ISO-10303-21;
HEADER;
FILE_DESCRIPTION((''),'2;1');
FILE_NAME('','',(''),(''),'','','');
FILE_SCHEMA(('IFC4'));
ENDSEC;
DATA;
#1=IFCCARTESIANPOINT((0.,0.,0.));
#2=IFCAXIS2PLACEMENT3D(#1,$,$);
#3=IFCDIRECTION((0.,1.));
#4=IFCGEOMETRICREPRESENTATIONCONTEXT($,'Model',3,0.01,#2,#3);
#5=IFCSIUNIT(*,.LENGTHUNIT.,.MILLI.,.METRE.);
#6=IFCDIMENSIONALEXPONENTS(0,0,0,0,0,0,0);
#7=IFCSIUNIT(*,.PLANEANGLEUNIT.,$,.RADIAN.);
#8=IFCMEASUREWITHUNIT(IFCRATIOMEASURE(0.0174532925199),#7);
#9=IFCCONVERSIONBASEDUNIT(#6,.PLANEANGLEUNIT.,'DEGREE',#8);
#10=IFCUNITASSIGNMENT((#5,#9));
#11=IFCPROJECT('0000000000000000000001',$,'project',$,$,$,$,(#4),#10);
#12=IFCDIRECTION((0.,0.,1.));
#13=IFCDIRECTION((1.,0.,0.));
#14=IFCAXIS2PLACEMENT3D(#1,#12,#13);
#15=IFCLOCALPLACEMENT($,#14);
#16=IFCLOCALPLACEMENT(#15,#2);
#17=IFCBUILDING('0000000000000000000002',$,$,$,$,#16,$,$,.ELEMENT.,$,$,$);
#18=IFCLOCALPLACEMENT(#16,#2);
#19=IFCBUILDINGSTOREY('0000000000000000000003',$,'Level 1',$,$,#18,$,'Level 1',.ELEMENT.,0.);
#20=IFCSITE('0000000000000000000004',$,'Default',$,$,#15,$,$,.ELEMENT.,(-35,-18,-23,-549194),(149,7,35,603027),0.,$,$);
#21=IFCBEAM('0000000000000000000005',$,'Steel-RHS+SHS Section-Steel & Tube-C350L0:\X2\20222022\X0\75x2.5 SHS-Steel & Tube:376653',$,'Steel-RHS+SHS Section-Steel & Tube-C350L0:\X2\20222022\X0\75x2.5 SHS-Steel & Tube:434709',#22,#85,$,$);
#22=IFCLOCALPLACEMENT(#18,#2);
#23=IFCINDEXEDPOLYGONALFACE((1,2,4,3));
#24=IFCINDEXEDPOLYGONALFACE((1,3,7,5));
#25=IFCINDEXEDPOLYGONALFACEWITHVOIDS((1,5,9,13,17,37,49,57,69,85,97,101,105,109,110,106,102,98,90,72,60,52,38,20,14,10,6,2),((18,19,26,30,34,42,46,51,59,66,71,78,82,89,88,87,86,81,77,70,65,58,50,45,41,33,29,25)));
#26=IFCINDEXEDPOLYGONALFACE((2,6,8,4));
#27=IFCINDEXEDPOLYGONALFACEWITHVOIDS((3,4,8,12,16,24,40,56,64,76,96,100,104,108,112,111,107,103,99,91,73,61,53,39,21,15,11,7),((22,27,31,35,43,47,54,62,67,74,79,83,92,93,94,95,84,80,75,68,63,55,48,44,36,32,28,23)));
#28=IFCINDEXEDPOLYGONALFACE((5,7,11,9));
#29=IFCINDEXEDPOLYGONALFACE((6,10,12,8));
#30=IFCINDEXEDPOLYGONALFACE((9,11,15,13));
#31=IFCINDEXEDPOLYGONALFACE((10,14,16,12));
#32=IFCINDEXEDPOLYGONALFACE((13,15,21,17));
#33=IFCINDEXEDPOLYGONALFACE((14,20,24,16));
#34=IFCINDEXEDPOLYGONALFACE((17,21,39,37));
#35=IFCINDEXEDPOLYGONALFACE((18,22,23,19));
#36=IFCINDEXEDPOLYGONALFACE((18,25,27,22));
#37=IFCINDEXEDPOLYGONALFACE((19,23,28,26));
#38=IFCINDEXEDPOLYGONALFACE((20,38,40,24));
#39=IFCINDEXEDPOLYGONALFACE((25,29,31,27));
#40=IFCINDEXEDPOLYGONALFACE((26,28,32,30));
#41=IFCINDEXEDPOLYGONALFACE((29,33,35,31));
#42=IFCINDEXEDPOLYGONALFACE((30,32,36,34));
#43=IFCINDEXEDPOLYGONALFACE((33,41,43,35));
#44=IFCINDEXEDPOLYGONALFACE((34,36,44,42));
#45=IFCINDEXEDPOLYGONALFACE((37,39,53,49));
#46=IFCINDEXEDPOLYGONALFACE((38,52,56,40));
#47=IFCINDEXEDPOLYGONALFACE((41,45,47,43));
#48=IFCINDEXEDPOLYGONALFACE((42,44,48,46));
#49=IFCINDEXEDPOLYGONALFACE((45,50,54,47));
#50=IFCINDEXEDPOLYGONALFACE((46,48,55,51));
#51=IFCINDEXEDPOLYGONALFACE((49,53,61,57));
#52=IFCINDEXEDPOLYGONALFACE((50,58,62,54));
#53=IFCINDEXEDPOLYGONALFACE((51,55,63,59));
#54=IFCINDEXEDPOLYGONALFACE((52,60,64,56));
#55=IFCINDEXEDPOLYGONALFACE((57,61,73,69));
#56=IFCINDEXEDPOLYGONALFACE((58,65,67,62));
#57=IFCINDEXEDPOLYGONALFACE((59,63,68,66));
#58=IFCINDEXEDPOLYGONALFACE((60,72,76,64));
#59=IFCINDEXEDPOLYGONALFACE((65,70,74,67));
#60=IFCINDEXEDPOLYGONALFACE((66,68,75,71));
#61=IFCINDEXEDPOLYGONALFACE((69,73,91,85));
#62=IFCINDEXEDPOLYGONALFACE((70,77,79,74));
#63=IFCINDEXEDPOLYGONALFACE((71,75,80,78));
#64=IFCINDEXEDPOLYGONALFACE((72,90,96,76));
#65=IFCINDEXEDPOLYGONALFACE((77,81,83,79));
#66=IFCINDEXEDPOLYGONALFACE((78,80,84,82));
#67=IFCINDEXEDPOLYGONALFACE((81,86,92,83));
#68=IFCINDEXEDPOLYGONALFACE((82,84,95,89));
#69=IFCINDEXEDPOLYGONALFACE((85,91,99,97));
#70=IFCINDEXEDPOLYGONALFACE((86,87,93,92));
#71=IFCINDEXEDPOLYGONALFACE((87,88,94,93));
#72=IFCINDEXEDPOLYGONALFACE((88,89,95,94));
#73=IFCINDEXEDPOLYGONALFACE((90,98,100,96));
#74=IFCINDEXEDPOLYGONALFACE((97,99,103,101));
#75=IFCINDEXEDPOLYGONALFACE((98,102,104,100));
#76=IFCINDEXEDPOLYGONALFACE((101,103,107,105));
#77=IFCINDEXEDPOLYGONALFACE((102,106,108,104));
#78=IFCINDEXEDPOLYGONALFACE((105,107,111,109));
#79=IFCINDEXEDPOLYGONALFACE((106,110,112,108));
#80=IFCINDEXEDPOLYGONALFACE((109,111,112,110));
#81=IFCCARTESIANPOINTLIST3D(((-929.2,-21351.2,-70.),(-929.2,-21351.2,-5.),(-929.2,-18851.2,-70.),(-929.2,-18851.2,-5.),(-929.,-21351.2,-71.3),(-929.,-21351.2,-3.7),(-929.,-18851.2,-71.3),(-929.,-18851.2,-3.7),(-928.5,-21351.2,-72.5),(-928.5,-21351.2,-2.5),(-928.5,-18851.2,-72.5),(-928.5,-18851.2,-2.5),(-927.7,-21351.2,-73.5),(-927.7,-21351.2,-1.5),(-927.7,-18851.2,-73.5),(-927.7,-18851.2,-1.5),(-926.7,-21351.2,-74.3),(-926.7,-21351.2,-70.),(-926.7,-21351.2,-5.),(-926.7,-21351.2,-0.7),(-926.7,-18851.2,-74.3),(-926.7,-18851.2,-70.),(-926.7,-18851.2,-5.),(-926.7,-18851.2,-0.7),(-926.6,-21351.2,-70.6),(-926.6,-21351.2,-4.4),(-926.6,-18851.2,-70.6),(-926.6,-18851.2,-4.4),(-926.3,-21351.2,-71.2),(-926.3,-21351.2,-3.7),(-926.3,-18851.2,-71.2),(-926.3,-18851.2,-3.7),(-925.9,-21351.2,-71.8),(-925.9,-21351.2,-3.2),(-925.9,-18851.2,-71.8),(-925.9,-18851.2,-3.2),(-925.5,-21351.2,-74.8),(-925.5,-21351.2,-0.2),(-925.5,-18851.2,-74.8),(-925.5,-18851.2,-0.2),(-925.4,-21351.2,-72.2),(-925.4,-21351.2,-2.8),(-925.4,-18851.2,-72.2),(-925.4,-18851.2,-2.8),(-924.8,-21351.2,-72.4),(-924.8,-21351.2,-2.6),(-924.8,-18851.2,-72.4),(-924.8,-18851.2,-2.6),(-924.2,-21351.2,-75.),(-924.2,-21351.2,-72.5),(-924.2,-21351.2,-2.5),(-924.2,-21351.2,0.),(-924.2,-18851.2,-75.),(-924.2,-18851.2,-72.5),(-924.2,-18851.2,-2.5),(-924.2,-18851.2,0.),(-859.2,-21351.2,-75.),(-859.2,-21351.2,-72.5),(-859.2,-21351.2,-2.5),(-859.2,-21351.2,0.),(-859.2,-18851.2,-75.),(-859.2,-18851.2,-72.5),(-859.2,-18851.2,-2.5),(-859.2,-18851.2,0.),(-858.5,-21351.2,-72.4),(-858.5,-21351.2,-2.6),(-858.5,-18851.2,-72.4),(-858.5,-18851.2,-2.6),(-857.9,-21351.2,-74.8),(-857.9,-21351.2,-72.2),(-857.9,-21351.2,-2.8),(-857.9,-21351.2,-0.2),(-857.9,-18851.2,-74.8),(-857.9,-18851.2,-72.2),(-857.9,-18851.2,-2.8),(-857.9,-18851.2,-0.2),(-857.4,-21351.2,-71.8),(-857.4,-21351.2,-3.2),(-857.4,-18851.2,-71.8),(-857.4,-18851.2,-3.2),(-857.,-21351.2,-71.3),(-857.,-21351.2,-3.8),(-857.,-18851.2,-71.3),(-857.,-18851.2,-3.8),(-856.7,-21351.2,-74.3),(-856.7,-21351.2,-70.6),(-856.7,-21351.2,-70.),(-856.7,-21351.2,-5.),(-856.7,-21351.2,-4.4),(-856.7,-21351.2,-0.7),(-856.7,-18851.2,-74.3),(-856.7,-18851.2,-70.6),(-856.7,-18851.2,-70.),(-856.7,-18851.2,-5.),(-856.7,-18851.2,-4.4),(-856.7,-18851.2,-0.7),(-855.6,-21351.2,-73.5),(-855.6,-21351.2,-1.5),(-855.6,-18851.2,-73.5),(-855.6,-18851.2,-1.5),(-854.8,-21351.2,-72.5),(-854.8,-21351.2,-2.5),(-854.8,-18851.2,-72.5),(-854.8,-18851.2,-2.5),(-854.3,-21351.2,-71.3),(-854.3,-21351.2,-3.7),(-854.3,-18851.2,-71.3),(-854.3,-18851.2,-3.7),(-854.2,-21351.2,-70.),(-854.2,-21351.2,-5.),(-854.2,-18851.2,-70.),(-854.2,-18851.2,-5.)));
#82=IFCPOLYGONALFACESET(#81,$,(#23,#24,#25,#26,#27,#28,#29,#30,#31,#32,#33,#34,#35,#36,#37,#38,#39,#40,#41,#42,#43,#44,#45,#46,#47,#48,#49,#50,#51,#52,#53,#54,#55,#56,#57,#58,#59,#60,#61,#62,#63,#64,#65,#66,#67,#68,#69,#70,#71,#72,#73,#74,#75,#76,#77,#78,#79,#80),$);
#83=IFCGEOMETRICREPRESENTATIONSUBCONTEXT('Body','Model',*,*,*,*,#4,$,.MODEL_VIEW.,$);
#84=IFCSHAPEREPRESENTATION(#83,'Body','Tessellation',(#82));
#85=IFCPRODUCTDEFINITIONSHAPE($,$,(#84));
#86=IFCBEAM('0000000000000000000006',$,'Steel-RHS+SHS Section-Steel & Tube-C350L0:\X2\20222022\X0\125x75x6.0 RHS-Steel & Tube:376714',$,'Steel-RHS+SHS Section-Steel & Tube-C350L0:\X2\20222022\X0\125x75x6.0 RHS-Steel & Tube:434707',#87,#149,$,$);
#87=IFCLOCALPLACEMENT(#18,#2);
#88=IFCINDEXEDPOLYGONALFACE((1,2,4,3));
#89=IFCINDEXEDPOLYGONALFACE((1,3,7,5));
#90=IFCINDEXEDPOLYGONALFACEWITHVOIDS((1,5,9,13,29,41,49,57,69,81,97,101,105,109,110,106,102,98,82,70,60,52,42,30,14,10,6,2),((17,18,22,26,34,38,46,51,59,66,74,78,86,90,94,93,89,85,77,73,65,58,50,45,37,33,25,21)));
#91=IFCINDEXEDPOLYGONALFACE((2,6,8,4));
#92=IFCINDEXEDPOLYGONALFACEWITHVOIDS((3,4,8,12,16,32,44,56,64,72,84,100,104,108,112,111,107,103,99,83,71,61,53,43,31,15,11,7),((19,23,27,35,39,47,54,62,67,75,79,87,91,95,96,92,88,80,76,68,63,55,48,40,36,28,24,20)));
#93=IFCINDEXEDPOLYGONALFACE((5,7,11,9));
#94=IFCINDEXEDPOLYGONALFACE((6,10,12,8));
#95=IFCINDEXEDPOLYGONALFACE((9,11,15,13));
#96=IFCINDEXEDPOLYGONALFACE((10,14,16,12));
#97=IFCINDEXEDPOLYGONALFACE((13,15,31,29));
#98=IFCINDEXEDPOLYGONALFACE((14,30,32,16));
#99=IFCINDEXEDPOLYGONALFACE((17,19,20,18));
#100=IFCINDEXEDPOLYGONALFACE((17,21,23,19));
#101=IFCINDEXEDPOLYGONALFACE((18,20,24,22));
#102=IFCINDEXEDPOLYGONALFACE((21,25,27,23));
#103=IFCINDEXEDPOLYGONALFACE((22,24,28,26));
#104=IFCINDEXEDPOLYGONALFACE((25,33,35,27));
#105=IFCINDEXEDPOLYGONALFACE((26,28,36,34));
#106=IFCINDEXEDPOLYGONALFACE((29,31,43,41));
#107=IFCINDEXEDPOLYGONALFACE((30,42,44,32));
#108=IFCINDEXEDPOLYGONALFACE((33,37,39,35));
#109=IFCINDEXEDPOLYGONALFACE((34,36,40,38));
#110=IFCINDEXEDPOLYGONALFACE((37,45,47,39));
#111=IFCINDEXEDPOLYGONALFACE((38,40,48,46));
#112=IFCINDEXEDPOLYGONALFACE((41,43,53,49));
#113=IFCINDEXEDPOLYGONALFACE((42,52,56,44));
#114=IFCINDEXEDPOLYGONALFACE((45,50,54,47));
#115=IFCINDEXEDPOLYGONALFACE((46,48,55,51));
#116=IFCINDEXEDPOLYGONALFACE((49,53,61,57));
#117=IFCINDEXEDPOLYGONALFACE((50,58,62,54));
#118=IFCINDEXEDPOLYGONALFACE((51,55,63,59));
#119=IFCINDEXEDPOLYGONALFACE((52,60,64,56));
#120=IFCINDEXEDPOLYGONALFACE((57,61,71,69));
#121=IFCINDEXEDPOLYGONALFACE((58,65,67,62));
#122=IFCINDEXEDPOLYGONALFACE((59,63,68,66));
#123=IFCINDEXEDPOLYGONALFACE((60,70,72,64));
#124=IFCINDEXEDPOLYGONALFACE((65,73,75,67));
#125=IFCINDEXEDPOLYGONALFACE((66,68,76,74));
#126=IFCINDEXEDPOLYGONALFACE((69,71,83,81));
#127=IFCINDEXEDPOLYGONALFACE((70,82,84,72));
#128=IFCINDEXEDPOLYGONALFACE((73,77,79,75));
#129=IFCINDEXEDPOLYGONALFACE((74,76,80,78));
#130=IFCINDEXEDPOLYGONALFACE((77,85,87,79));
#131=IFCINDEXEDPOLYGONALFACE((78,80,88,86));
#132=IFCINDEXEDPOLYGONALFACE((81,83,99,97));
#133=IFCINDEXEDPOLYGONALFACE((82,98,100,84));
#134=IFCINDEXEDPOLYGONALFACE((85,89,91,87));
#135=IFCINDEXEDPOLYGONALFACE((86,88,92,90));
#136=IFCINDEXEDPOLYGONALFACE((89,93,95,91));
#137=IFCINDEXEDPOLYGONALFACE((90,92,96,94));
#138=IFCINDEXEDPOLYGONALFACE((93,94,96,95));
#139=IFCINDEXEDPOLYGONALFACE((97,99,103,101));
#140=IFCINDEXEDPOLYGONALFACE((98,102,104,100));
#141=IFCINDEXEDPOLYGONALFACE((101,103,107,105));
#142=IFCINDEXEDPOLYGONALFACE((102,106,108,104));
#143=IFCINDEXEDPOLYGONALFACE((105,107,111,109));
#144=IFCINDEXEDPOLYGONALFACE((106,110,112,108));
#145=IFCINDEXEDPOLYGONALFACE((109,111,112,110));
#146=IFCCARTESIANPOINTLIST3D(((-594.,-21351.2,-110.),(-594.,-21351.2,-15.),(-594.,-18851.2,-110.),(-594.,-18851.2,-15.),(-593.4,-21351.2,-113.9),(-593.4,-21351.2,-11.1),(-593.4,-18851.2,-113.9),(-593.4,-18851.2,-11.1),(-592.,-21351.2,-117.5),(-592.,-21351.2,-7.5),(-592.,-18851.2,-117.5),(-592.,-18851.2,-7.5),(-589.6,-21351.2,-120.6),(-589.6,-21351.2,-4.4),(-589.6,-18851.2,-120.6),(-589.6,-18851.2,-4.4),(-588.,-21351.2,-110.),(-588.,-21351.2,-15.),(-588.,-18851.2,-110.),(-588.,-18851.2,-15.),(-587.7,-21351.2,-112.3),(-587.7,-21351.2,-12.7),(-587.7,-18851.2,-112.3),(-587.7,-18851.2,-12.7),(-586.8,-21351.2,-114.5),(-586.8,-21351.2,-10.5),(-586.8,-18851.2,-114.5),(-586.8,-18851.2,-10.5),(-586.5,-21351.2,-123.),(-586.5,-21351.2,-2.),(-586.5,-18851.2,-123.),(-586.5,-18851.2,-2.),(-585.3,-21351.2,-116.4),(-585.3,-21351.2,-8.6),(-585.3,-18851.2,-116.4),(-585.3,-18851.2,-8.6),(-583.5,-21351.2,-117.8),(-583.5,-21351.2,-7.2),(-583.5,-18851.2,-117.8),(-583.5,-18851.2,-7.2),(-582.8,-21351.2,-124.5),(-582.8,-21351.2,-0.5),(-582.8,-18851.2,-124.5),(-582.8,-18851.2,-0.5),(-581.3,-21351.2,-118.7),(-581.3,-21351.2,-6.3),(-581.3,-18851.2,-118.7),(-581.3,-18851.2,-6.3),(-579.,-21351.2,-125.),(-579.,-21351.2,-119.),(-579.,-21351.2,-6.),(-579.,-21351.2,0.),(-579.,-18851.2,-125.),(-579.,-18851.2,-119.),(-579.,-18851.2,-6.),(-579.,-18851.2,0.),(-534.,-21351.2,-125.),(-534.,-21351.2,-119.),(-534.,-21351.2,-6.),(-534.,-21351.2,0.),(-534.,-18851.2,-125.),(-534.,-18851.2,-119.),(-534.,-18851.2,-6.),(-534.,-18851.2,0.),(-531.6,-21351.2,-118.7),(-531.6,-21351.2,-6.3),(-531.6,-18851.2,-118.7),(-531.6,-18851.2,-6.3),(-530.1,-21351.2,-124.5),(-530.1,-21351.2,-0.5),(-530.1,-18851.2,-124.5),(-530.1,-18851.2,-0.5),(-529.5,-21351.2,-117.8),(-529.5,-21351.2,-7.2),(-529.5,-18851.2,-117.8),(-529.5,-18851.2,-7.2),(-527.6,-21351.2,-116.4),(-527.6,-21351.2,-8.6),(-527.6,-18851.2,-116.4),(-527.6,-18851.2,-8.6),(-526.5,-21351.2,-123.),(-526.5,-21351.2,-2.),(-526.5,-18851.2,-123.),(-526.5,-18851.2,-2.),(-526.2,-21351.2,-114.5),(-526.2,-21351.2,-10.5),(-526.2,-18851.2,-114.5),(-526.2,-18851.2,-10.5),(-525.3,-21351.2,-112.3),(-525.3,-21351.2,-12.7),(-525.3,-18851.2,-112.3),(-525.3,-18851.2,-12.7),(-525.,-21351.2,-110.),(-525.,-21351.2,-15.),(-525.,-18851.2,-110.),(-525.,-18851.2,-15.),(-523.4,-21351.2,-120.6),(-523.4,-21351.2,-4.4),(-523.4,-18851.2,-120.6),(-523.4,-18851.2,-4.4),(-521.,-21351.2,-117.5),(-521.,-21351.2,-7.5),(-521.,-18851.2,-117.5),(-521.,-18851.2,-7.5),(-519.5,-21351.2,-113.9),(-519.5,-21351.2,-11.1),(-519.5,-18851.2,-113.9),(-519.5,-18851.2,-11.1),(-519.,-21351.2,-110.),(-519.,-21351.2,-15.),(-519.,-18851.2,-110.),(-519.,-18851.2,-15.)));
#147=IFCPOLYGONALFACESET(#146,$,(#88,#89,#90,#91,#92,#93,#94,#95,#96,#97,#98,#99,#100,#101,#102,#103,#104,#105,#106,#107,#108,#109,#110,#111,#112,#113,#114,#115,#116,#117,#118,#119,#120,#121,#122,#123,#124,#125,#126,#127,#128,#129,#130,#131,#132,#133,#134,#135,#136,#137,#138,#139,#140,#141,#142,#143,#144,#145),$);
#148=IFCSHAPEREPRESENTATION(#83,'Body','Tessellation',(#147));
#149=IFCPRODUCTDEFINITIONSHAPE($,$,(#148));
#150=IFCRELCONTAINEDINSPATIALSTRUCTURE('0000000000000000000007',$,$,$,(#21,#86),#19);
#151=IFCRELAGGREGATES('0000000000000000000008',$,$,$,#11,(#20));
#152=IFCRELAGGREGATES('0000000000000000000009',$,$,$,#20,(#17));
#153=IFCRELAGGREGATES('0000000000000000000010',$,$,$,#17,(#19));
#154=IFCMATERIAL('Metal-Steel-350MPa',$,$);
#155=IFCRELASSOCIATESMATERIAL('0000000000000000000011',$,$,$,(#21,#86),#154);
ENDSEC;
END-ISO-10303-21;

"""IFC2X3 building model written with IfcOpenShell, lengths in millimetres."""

from ifc_helpers import new_model, entity, si_unit, converted_unit, direction, frame, frame_2d, origin, origin_with_axes, place, context, subcontext, project, spatial, polyline, circle_curve, parameter, trimmed, segment, composite_curve, outline, extrude, material, element, save


model = new_model("IFC2X3")

# Units and contexts
model_context = context("Model", 3, precision=0.01, world=origin(), true_north=direction((0.0, 1.0)))
body_context = subcontext(model_context, "Body", "Model", "MODEL_VIEW")
ifc_project = project(units=[si_unit("LENGTHUNIT", "METRE", prefix="MILLI"), converted_unit("PLANEANGLEUNIT", "DEGREE", entity("IfcRatioMeasure", 0.0174532925199), si_unit("PLANEANGLEUNIT", "RADIAN"), dimensions=[0, 0, 0, 0, 0, 0, 0])], contexts=[model_context])

# Site, building, storey
site_placement = place(None, origin_with_axes())
site = spatial("IfcSite", under=ifc_project, at=site_placement, Name="Default", CompositionType="ELEMENT", RefLatitude=(-35, -18, -23, -549194), RefLongitude=(149, 7, 35, 603027), RefElevation=0.0)
building_placement = place(site_placement, origin())
building = spatial("IfcBuilding", under=site, at=building_placement, CompositionType="ELEMENT")
storey_placement = place(building_placement, origin())
storey = spatial("IfcBuildingStorey", under=building, at=storey_placement, Name="Level 1", LongName="Level 1", CompositionType="ELEMENT", Elevation=0.0)

# Beams
ifc_material = material(Name="Metal-Steel-350MPa")
beam_1_placement = place(storey_placement, frame((-891.7, -18851.2, 0.0), z_axis=(0.0, 0.0, 1.0), x_axis=(0.0, -1.0, 0.0)))
element("IfcBeam", 1, at=beam_1_placement, inside=storey, material=ifc_material, Name="Steel-RHS+SHS Section-Steel & Tube-C350L0:••75x2.5 SHS-Steel & Tube:376653", ObjectType="Steel-RHS+SHS Section-Steel & Tube-C350L0:••75x2.5 SHS-Steel & Tube:434709", context=body_context, shape_type="SweptSolid", body=[
    extrude(outline(composite_curve([segment(trimmed(circle_curve(frame_2d((-32.5, -32.5), x_axis=(1.0, 0.0)), 5.0), [parameter(180.0)], [parameter(270.0)], True, "PARAMETER"), True, "CONTINUOUS"), segment(polyline([(-32.5, -37.5), (32.5, -37.5)]), True, "CONTINUOUS"), segment(trimmed(circle_curve(frame_2d((32.5, -32.5), x_axis=(1.0, 0.0)), 5.0), [parameter(270.0)], [parameter(0.0)], True, "PARAMETER"), True, "CONTINUOUS"), segment(polyline([(37.5, -32.5), (37.5, 32.5)]), True, "CONTINUOUS"), segment(trimmed(circle_curve(frame_2d((32.5, 32.5), x_axis=(1.0, 0.0)), 5.0), [parameter(0.0)], [parameter(90.0)], True, "PARAMETER"), True, "CONTINUOUS"), segment(polyline([(32.5, 37.5), (-32.5, 37.5)]), True, "CONTINUOUS"), segment(trimmed(circle_curve(frame_2d((-32.5, 32.5), x_axis=(1.0, 0.0)), 5.0), [parameter(90.0)], [parameter(180.0)], True, "PARAMETER"), True, "CONTINUOUS"), segment(polyline([(-37.5, 32.5), (-37.5, -32.5)]), True, "CONTINUOUS")], self_intersect=False), holes=[composite_curve([segment(polyline([(32.5, -35.0), (-32.5, -35.0)]), True, "CONTINUOUS"), segment(trimmed(circle_curve(frame_2d((-32.5, -32.5), x_axis=(1.0, 0.0)), 2.5), [parameter(180.0)], [parameter(270.0)], True, "PARAMETER"), False, "CONTINUOUS"), segment(polyline([(-35.0, -32.5), (-35.0, 32.5)]), True, "CONTINUOUS"), segment(trimmed(circle_curve(frame_2d((-32.5, 32.5), x_axis=(1.0, 0.0)), 2.5), [parameter(90.0)], [parameter(180.0)], True, "PARAMETER"), False, "CONTINUOUS"), segment(polyline([(-32.5, 35.0), (32.5, 35.0)]), True, "CONTINUOUS"), segment(trimmed(circle_curve(frame_2d((32.5, 32.5), x_axis=(1.0, 0.0)), 2.5), [parameter(360.0)], [parameter(90.0)], True, "PARAMETER"), False, "CONTINUOUS"), segment(polyline([(35.0, 32.5), (35.0, -32.5)]), True, "CONTINUOUS"), segment(trimmed(circle_curve(frame_2d((32.5, -32.5), x_axis=(1.0, 0.0)), 2.5), [parameter(270.0)], [parameter(0.0)], True, "PARAMETER"), False, "CONTINUOUS")], self_intersect=False)]), frame((0.0, 0.0, -37.5), z_axis=(1.0, 0.0, 0.0), x_axis=(0.0, -1.0, 0.0)), (0.0, 0.0, 1.0), 2500.0),
])
beam_2_placement = place(storey_placement, frame((-556.5, -18851.2, 0.0), z_axis=(0.0, 0.0, 1.0), x_axis=(0.0, -1.0, 0.0)))
element("IfcBeam", 2, at=beam_2_placement, inside=storey, material=ifc_material, Name="Steel-RHS+SHS Section-Steel & Tube-C350L0:••125x75x6.0 RHS-Steel & Tube:376714", ObjectType="Steel-RHS+SHS Section-Steel & Tube-C350L0:••125x75x6.0 RHS-Steel & Tube:434707", context=body_context, shape_type="SweptSolid", body=[
    extrude(outline(composite_curve([segment(trimmed(circle_curve(frame_2d((-22.5, -47.5), x_axis=(1.0, 0.0)), 15.0), [parameter(180.0)], [parameter(270.0)], True, "PARAMETER"), True, "CONTINUOUS"), segment(polyline([(-22.5, -62.5), (22.5, -62.5)]), True, "CONTINUOUS"), segment(trimmed(circle_curve(frame_2d((22.5, -47.5), x_axis=(1.0, 0.0)), 15.0), [parameter(270.0)], [parameter(0.0)], True, "PARAMETER"), True, "CONTINUOUS"), segment(polyline([(37.5, -47.5), (37.5, 47.5)]), True, "CONTINUOUS"), segment(trimmed(circle_curve(frame_2d((22.5, 47.5), x_axis=(1.0, 0.0)), 15.0), [parameter(0.0)], [parameter(90.0)], True, "PARAMETER"), True, "CONTINUOUS"), segment(polyline([(22.5, 62.5), (-22.5, 62.5)]), True, "CONTINUOUS"), segment(trimmed(circle_curve(frame_2d((-22.5, 47.5), x_axis=(1.0, 0.0)), 15.0), [parameter(90.0)], [parameter(180.0)], True, "PARAMETER"), True, "CONTINUOUS"), segment(polyline([(-37.5, 47.5), (-37.5, -47.5)]), True, "CONTINUOUS")], self_intersect=False), holes=[composite_curve([segment(polyline([(22.5, -56.5), (-22.5, -56.5)]), True, "CONTINUOUS"), segment(trimmed(circle_curve(frame_2d((-22.5, -47.5), x_axis=(1.0, 0.0)), 9.0), [parameter(180.0)], [parameter(270.0)], True, "PARAMETER"), False, "CONTINUOUS"), segment(polyline([(-31.5, -47.5), (-31.5, 47.5)]), True, "CONTINUOUS"), segment(trimmed(circle_curve(frame_2d((-22.5, 47.5), x_axis=(1.0, 0.0)), 9.0), [parameter(90.0)], [parameter(180.0)], True, "PARAMETER"), False, "CONTINUOUS"), segment(polyline([(-22.5, 56.5), (22.5, 56.5)]), True, "CONTINUOUS"), segment(trimmed(circle_curve(frame_2d((22.5, 47.5), x_axis=(1.0, 0.0)), 9.0), [parameter(360.0)], [parameter(90.0)], True, "PARAMETER"), False, "CONTINUOUS"), segment(polyline([(31.5, 47.5), (31.5, -47.5)]), True, "CONTINUOUS"), segment(trimmed(circle_curve(frame_2d((22.5, -47.5), x_axis=(1.0, 0.0)), 9.0), [parameter(270.0)], [parameter(360.0)], True, "PARAMETER"), False, "CONTINUOUS")], self_intersect=False)]), frame((0.0, 0.0, -62.5), z_axis=(1.0, 0.0, 0.0), x_axis=(0.0, -1.0, 0.0)), (0.0, 0.0, 1.0), 2500.0),
])

save(model, "model.ifc")
